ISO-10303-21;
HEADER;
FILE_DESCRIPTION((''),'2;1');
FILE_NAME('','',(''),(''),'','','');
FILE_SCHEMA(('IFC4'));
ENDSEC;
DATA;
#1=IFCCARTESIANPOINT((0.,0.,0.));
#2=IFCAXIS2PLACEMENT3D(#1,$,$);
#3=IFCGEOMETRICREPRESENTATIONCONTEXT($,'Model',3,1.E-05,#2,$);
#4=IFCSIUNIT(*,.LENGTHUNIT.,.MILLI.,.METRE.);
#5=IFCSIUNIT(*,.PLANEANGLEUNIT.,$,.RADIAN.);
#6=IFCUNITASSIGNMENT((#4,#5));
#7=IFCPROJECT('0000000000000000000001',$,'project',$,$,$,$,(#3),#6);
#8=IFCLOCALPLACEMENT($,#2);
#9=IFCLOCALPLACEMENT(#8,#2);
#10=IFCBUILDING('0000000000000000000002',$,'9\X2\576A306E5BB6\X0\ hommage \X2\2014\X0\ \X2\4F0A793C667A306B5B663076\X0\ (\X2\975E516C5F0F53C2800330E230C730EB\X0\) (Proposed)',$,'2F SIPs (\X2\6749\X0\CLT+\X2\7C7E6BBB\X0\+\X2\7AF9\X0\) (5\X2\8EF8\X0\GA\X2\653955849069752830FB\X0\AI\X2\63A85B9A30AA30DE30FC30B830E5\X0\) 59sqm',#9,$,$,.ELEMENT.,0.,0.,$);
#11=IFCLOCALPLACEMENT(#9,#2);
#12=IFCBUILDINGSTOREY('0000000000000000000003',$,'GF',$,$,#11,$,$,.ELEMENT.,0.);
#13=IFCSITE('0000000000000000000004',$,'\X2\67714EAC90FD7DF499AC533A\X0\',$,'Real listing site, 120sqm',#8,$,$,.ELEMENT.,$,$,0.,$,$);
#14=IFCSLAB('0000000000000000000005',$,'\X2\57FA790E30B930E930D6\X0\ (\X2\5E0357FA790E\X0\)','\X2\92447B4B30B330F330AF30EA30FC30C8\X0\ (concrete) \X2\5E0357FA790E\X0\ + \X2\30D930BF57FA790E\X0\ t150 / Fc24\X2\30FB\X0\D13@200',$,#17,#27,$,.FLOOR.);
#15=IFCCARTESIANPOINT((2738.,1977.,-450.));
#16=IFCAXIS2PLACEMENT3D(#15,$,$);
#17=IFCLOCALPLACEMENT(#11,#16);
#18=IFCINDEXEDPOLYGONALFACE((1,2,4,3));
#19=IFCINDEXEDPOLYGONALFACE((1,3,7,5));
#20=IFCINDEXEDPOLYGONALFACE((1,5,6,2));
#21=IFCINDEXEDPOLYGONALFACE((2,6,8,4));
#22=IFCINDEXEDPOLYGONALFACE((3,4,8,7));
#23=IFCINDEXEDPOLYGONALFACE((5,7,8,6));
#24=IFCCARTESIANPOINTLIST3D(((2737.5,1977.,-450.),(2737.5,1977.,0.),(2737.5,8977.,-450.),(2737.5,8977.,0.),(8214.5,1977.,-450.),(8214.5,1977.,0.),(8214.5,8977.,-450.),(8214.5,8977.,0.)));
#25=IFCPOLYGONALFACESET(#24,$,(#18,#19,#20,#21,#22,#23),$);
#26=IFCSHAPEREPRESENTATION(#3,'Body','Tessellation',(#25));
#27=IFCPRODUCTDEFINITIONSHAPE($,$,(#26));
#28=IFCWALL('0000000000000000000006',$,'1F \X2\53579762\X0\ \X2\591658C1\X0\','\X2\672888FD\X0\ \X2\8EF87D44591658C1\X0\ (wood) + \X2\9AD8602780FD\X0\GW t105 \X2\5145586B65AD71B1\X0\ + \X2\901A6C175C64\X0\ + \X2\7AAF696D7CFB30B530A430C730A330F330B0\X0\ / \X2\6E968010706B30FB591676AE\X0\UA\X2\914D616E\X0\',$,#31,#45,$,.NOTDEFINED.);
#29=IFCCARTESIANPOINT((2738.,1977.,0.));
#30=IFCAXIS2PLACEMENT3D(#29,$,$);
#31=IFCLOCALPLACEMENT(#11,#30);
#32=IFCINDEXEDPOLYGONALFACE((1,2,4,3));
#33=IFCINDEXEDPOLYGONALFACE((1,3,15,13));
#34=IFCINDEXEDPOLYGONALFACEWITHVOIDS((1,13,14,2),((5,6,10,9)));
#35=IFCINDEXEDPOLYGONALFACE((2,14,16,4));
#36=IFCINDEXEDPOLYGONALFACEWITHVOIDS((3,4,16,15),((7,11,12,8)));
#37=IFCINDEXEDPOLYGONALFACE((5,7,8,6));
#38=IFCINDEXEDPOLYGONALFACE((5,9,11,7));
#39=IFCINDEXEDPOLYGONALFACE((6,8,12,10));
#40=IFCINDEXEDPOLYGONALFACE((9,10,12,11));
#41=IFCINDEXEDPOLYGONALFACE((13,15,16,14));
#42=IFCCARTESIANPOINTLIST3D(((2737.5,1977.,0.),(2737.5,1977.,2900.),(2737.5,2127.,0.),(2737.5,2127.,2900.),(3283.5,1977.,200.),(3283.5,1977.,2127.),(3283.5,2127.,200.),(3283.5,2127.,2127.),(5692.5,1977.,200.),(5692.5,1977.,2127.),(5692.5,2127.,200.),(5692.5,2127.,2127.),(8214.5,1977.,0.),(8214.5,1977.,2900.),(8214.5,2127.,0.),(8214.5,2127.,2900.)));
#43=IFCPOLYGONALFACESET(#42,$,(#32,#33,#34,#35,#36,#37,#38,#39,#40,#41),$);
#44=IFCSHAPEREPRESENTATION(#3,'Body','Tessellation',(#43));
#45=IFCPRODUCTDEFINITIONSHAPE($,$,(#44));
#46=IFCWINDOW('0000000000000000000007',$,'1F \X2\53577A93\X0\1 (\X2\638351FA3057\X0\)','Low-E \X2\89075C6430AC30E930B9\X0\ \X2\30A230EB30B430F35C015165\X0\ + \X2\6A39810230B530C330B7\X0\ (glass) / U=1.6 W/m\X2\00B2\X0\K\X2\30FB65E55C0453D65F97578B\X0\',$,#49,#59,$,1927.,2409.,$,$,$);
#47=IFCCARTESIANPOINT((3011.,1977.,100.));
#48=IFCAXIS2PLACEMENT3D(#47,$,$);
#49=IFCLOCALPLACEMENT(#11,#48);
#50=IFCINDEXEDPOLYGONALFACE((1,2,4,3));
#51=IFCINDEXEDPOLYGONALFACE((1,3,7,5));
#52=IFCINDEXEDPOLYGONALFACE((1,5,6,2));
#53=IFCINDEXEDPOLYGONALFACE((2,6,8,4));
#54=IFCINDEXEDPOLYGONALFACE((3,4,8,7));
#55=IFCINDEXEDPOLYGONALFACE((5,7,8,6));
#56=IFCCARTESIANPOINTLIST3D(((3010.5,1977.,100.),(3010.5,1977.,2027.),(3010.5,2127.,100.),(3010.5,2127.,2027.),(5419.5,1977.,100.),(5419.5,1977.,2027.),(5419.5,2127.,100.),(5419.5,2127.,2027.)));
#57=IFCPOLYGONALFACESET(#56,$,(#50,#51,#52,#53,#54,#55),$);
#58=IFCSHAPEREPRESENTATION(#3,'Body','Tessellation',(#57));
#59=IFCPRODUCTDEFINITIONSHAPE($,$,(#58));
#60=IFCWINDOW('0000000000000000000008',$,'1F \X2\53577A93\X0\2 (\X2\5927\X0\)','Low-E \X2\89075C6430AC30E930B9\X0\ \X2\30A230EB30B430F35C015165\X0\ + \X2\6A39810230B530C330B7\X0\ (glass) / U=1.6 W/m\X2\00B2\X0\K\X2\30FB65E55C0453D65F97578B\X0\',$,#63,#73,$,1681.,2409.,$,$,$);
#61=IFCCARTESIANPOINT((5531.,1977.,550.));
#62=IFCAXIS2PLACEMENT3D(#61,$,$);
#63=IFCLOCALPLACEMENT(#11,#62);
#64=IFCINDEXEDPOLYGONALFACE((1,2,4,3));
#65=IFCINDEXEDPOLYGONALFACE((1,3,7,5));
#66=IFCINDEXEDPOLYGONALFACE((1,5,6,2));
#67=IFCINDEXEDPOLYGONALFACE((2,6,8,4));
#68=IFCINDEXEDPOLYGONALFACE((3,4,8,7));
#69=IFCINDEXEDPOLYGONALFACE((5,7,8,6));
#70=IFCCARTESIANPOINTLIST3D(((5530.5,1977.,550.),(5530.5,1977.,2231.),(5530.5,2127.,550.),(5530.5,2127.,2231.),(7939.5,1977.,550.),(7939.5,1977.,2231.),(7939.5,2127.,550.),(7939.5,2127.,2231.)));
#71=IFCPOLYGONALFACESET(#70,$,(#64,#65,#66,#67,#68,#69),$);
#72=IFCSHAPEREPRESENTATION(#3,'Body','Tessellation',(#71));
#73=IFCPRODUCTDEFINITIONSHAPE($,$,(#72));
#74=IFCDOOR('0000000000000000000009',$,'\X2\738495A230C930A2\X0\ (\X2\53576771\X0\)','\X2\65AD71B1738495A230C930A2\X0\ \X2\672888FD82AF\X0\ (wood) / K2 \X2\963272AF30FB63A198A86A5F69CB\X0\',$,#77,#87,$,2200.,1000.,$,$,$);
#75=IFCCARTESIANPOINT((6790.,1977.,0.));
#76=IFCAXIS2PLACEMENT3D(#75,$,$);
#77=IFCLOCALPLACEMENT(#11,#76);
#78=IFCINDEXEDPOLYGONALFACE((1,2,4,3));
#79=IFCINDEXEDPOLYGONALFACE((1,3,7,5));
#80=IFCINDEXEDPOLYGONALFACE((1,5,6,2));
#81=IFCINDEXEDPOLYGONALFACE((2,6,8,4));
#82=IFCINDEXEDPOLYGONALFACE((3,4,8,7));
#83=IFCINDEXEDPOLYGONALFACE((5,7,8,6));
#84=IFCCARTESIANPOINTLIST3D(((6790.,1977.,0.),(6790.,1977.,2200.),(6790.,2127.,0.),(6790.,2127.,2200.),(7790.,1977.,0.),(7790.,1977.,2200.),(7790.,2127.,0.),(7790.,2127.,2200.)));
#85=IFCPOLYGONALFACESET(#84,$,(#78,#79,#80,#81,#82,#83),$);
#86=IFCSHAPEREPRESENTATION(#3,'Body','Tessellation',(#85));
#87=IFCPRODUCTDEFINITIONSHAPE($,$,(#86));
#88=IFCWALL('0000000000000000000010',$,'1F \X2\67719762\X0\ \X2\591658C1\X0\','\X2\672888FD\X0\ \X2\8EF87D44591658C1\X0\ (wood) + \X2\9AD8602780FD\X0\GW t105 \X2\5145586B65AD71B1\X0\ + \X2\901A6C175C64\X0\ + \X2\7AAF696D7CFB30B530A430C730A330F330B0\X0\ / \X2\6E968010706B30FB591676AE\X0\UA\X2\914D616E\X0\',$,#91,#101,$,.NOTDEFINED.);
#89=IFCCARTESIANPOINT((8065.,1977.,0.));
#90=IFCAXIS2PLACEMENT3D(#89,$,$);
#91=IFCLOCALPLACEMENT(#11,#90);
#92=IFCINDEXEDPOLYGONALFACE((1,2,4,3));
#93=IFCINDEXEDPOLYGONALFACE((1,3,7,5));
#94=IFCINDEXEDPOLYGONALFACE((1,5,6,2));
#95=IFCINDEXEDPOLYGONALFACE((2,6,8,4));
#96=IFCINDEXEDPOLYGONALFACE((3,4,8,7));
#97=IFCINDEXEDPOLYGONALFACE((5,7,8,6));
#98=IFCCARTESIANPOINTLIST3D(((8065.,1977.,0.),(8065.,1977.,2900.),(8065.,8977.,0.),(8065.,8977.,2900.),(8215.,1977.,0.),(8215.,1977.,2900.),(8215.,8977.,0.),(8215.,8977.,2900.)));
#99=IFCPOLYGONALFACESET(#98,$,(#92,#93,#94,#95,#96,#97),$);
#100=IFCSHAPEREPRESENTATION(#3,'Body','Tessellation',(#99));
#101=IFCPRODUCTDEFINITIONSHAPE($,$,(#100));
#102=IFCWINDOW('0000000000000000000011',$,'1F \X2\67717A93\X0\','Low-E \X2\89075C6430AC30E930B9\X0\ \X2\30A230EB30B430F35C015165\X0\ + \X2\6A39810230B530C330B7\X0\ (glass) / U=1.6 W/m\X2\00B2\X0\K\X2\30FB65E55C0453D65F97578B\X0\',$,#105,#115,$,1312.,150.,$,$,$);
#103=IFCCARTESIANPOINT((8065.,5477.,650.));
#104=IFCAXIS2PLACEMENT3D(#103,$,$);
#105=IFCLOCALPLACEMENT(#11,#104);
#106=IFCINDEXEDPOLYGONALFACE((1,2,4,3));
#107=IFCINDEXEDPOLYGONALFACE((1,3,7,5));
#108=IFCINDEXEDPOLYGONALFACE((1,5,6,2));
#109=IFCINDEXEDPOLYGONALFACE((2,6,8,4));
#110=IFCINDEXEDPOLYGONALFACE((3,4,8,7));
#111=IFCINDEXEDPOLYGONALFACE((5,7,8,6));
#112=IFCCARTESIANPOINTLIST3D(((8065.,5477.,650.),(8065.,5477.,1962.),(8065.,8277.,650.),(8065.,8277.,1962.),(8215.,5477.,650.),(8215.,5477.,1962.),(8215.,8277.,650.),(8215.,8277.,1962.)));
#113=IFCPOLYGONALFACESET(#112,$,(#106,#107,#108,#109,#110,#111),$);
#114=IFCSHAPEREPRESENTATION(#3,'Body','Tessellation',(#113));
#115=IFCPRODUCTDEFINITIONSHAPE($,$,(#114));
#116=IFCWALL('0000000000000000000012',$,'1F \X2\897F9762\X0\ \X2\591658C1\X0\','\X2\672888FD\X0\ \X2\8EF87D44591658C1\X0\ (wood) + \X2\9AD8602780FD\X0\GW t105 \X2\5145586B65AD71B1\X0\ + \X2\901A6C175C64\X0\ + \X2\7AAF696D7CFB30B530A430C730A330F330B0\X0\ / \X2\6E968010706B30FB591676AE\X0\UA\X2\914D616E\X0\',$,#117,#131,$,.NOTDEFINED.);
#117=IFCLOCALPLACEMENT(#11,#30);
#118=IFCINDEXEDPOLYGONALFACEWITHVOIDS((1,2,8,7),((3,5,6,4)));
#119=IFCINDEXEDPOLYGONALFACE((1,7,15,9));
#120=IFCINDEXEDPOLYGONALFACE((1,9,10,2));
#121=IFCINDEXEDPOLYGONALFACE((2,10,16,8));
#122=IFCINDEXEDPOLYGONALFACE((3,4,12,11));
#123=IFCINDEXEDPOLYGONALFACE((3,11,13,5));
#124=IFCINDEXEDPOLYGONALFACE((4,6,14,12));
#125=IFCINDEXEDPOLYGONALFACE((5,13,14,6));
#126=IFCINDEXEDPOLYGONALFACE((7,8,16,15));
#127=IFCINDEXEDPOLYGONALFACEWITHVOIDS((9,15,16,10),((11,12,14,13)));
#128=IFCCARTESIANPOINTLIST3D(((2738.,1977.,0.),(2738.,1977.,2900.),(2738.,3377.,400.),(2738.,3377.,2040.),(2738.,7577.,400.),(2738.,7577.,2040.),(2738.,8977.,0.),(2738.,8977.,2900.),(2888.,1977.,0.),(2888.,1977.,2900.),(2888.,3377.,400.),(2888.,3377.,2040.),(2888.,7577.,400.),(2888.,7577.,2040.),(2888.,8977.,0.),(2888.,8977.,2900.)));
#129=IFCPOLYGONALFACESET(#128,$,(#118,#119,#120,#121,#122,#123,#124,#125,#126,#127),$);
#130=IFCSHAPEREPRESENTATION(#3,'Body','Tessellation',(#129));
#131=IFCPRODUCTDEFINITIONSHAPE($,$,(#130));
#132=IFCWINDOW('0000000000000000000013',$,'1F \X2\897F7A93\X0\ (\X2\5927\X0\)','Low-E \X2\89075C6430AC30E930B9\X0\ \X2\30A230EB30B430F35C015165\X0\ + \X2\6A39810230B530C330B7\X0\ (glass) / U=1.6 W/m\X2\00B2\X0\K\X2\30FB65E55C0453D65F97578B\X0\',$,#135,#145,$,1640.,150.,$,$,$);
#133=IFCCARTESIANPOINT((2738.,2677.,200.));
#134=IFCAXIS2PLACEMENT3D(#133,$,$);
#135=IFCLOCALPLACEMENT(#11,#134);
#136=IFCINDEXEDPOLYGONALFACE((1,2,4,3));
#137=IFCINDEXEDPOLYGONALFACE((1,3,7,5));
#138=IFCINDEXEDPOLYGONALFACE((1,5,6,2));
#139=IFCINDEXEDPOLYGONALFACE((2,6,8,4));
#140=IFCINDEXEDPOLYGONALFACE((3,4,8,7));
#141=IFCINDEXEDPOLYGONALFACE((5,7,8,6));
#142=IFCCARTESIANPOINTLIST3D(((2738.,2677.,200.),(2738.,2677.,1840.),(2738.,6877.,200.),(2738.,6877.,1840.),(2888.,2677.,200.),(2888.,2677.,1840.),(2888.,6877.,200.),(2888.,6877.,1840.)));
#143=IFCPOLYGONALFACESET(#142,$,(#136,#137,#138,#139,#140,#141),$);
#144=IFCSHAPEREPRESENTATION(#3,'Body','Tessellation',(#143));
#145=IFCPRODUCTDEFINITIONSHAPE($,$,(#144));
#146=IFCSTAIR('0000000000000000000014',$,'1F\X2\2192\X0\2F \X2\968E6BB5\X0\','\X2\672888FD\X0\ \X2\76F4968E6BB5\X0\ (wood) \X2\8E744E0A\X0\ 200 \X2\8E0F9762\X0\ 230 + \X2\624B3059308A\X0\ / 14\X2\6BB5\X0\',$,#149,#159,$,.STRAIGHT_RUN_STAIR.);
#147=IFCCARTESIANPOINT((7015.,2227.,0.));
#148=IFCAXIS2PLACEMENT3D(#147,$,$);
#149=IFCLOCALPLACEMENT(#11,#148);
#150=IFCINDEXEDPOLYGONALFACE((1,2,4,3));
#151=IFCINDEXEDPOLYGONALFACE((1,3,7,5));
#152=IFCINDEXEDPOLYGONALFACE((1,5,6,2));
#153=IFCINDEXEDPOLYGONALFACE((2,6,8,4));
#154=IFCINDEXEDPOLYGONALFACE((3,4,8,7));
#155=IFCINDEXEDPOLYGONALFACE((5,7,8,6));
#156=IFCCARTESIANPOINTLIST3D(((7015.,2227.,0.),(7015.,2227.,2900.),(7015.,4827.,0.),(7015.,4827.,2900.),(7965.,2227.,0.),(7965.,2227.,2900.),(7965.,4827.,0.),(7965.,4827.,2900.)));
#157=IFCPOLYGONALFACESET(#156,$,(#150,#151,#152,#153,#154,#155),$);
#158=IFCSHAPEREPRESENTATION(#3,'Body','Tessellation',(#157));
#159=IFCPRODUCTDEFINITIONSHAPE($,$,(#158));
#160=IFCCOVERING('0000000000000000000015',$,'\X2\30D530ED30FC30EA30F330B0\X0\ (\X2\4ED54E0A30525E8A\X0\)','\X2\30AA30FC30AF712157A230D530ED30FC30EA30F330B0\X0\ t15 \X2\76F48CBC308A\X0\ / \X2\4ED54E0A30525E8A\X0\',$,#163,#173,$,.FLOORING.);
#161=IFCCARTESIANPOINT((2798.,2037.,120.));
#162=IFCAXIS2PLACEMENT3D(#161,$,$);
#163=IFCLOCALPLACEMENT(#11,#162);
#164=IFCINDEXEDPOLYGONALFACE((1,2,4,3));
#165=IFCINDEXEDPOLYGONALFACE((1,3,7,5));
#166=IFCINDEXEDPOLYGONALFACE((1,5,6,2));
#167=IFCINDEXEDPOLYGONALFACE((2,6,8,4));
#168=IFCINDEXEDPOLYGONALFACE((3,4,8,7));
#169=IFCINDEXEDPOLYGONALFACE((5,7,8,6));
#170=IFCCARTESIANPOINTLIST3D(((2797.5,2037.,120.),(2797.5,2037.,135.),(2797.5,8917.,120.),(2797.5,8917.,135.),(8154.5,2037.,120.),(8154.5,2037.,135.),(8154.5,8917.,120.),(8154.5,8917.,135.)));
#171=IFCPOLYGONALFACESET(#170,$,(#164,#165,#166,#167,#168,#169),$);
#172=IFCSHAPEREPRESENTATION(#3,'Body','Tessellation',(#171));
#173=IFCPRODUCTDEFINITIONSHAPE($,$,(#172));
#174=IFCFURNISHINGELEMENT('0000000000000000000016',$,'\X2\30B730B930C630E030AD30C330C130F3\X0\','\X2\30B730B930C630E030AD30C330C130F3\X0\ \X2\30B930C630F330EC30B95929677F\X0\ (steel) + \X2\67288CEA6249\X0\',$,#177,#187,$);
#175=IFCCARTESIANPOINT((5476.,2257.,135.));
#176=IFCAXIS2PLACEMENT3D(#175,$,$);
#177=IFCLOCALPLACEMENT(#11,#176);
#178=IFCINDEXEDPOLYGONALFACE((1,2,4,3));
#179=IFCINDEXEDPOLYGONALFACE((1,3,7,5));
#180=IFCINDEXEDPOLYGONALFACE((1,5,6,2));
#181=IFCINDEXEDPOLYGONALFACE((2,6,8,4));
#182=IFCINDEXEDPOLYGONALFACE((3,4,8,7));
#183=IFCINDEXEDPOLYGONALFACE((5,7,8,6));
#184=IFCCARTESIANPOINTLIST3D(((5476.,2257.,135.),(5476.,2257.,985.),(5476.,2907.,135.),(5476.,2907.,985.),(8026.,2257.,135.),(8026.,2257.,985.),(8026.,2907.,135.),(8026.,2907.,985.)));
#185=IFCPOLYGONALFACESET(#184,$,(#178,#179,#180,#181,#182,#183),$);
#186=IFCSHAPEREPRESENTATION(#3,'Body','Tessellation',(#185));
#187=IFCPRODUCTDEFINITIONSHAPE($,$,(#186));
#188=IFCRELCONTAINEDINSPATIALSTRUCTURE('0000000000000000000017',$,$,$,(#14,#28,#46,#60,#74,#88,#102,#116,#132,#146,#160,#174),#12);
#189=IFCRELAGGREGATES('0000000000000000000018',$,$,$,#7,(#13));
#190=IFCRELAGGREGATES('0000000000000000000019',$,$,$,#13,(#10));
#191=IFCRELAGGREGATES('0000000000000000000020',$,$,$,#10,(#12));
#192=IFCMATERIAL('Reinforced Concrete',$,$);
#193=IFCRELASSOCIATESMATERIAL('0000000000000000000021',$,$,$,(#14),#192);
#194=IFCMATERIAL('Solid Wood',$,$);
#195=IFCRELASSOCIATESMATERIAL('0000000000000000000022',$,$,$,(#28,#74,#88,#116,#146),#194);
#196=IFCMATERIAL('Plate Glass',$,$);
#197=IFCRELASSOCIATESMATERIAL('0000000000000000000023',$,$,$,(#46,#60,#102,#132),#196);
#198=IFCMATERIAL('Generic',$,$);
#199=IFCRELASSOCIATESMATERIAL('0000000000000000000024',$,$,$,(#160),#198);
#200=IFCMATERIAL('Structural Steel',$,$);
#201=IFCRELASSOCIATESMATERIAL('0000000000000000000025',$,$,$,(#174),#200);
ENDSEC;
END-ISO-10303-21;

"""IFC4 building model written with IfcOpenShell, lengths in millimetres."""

from ifc_helpers import new_model, si_unit, frame, frame_2d, origin, place, context, project, spatial, rectangle, extrude, material, element, fill, save


model = new_model("IFC4")

# Units and contexts
model_context = context("Model", 3, precision=1e-05, world=origin())
ifc_project = project(units=[si_unit("LENGTHUNIT", "METRE", prefix="MILLI"), si_unit("PLANEANGLEUNIT", "RADIAN")], contexts=[model_context])

# Site, building, storey
site_placement = place(None, origin())
site = spatial("IfcSite", under=ifc_project, at=site_placement, Name="東京都練馬区", ObjectType="Real listing site, 120sqm", CompositionType="ELEMENT", RefElevation=0.0)
building_placement = place(site_placement, origin())
building = spatial("IfcBuilding", under=site, at=building_placement, Name="9坪の家 hommage — 伊礼智に学ぶ (非公式参考モデル) (Proposed)", ObjectType="2F SIPs (杉CLT+籾殻+竹) (5軸GA改善適用・AI推定オマージュ) 59sqm", CompositionType="ELEMENT", ElevationOfRefHeight=0.0, ElevationOfTerrain=0.0)
storey_placement = place(building_placement, origin())
storey = spatial("IfcBuildingStorey", under=building, at=storey_placement, Name="GF", CompositionType="ELEMENT", Elevation=0.0)

# Slab
ifc_material_1 = material(Name="Reinforced Concrete")
slab_1_placement = place(storey_placement, frame((2738.0, 1977.0, -450.0)))
element("IfcSlab", 1, at=slab_1_placement, inside=storey, material=ifc_material_1, Name="基礎スラブ (布基礎)", Description="鉄筋コンクリート (concrete) 布基礎 + ベタ基礎 t150 / Fc24・D13@200", PredefinedType="FLOOR", context=model_context, shape_type="SweptSolid", body=[
    extrude(rectangle(XDim=5477.0, YDim=7000.0, at=frame_2d((2738.0, 3500.0))), frame((2738.0, 1977.0, -450.0)), (0.0, 0.0, 1.0), 450.0),
])
ifc_material_2 = material(Name="Solid Wood")

# Wall, openings, windows, door
wall_1_placement = place(storey_placement, frame((2738.0, 1977.0, 0.0)))
wall_1 = element("IfcWall", 2, at=wall_1_placement, inside=storey, material=ifc_material_2, Name="1F 南面 外壁", Description="木製 軸組外壁 (wood) + 高性能GW t105 充填断熱 + 通気層 + 窯業系サイディング / 準耐火・外皮UA配慮", PredefinedType="NOTDEFINED", context=model_context, shape_type="SweptSolid", body=[
    extrude(rectangle(XDim=5477.0, YDim=150.0, at=frame_2d((2738.0, 75.0))), frame((2738.0, 1977.0, 0.0)), (0.0, 0.0, 1.0), 2900.0),
])
opening_1_placement = place(storey_placement, frame((3011.0, 1977.0, 100.0)))
opening_1 = element("IfcOpeningElement", 3, at=opening_1_placement, cuts=wall_1, PredefinedType="NOTDEFINED", context=model_context, shape_type="SweptSolid", body=[
    extrude(rectangle(XDim=2409.0, YDim=150.0, at=frame_2d((1204.0, 75.0))), frame((3011.0, 1977.0, 100.0)), (0.0, 0.0, 1.0), 1927.0),
])
opening_2_placement = place(storey_placement, frame((5531.0, 1977.0, 550.0)))
opening_2 = element("IfcOpeningElement", 4, at=opening_2_placement, cuts=wall_1, PredefinedType="NOTDEFINED", context=model_context, shape_type="SweptSolid", body=[
    extrude(rectangle(XDim=2409.0, YDim=150.0, at=frame_2d((1204.0, 75.0))), frame((5531.0, 1977.0, 550.0)), (0.0, 0.0, 1.0), 1681.0),
])
opening_3_placement = place(storey_placement, frame((6790.0, 1977.0, 0.0)))
opening_3 = element("IfcOpeningElement", 5, at=opening_3_placement, cuts=wall_1, PredefinedType="NOTDEFINED", context=model_context, shape_type="SweptSolid", body=[
    extrude(rectangle(XDim=1000.0, YDim=150.0, at=frame_2d((500.0, 75.0))), frame((6790.0, 1977.0, 0.0)), (0.0, 0.0, 1.0), 2200.0),
])
ifc_material_3 = material(Name="Plate Glass")
window_1_placement = place(storey_placement, frame((3011.0, 1977.0, 100.0)))
window_1 = element("IfcWindow", 6, at=window_1_placement, inside=storey, material=ifc_material_3, Name="1F 南窓1 (掃出し)", Description="Low-E 複層ガラス アルゴン封入 + 樹脂サッシ (glass) / U=1.6 W/m²K・日射取得型", OverallHeight=1927.0, OverallWidth=2409.0, context=model_context, shape_type="SweptSolid", body=[
    extrude(rectangle(XDim=2409.0, YDim=150.0, at=frame_2d((1204.0, 75.0))), frame((3011.0, 1977.0, 100.0)), (0.0, 0.0, 1.0), 1927.0),
])
fill(opening_1, window_1)
window_2_placement = place(storey_placement, frame((5531.0, 1977.0, 550.0)))
window_2 = element("IfcWindow", 7, at=window_2_placement, inside=storey, material=ifc_material_3, Name="1F 南窓2 (大)", Description="Low-E 複層ガラス アルゴン封入 + 樹脂サッシ (glass) / U=1.6 W/m²K・日射取得型", OverallHeight=1681.0, OverallWidth=2409.0, context=model_context, shape_type="SweptSolid", body=[
    extrude(rectangle(XDim=2409.0, YDim=150.0, at=frame_2d((1204.0, 75.0))), frame((5531.0, 1977.0, 550.0)), (0.0, 0.0, 1.0), 1681.0),
])
fill(opening_2, window_2)
door_placement = place(storey_placement, frame((6790.0, 1977.0, 0.0)))
door = element("IfcDoor", 8, at=door_placement, inside=storey, material=ifc_material_2, Name="玄関ドア (南東)", Description="断熱玄関ドア 木製芯 (wood) / K2 防犯・採風機構", OverallHeight=2200.0, OverallWidth=1000.0, context=model_context, shape_type="SweptSolid", body=[
    extrude(rectangle(XDim=1000.0, YDim=150.0, at=frame_2d((500.0, 75.0))), frame((6790.0, 1977.0, 0.0)), (0.0, 0.0, 1.0), 2200.0),
])
fill(opening_3, door)

# Walls, openings, windows
wall_2_placement = place(storey_placement, frame((8065.0, 1977.0, 0.0)))
wall_2 = element("IfcWall", 9, at=wall_2_placement, inside=storey, material=ifc_material_2, Name="1F 東面 外壁", Description="木製 軸組外壁 (wood) + 高性能GW t105 充填断熱 + 通気層 + 窯業系サイディング / 準耐火・外皮UA配慮", PredefinedType="NOTDEFINED", context=model_context, shape_type="SweptSolid", body=[
    extrude(rectangle(XDim=150.0, YDim=7000.0, at=frame_2d((75.0, 3500.0))), frame((8065.0, 1977.0, 0.0)), (0.0, 0.0, 1.0), 2900.0),
])
opening_4_placement = place(storey_placement, frame((8065.0, 5477.0, 650.0)))
opening_4 = element("IfcOpeningElement", 10, at=opening_4_placement, cuts=wall_2, PredefinedType="NOTDEFINED", context=model_context, shape_type="SweptSolid", body=[
    extrude(rectangle(XDim=150.0, YDim=2800.0, at=frame_2d((75.0, 1400.0))), frame((8065.0, 5477.0, 650.0)), (0.0, 0.0, 1.0), 1312.0),
])
window_3_placement = place(storey_placement, frame((8065.0, 5477.0, 650.0)))
window_3 = element("IfcWindow", 11, at=window_3_placement, inside=storey, material=ifc_material_3, Name="1F 東窓", Description="Low-E 複層ガラス アルゴン封入 + 樹脂サッシ (glass) / U=1.6 W/m²K・日射取得型", OverallHeight=1312.0, OverallWidth=150.0, context=model_context, shape_type="SweptSolid", body=[
    extrude(rectangle(XDim=150.0, YDim=2800.0, at=frame_2d((75.0, 1400.0))), frame((8065.0, 5477.0, 650.0)), (0.0, 0.0, 1.0), 1312.0),
])
fill(opening_4, window_3)
wall_3_placement = place(storey_placement, frame((2738.0, 1977.0, 0.0)))
wall_3 = element("IfcWall", 12, at=wall_3_placement, inside=storey, material=ifc_material_2, Name="1F 西面 外壁", Description="木製 軸組外壁 (wood) + 高性能GW t105 充填断熱 + 通気層 + 窯業系サイディング / 準耐火・外皮UA配慮", PredefinedType="NOTDEFINED", context=model_context, shape_type="SweptSolid", body=[
    extrude(rectangle(XDim=150.0, YDim=7000.0, at=frame_2d((75.0, 3500.0))), frame((2738.0, 1977.0, 0.0)), (0.0, 0.0, 1.0), 2900.0),
])
opening_5_placement = place(storey_placement, frame((2738.0, 2677.0, 200.0)))
opening_5 = element("IfcOpeningElement", 13, at=opening_5_placement, cuts=wall_3, PredefinedType="NOTDEFINED", context=model_context, shape_type="SweptSolid", body=[
    extrude(rectangle(XDim=150.0, YDim=4200.0, at=frame_2d((75.0, 2100.0))), frame((2738.0, 2677.0, 200.0)), (0.0, 0.0, 1.0), 1640.0),
])
window_4_placement = place(storey_placement, frame((2738.0, 2677.0, 200.0)))
window_4 = element("IfcWindow", 14, at=window_4_placement, inside=storey, material=ifc_material_3, Name="1F 西窓 (大)", Description="Low-E 複層ガラス アルゴン封入 + 樹脂サッシ (glass) / U=1.6 W/m²K・日射取得型", OverallHeight=1640.0, OverallWidth=150.0, context=model_context, shape_type="SweptSolid", body=[
    extrude(rectangle(XDim=150.0, YDim=4200.0, at=frame_2d((75.0, 2100.0))), frame((2738.0, 2677.0, 200.0)), (0.0, 0.0, 1.0), 1640.0),
])
fill(opening_5, window_4)

# Stair
stair_placement = place(storey_placement, frame((7015.0, 2227.0, 0.0)))
element("IfcStair", 15, at=stair_placement, inside=storey, material=ifc_material_2, Name="1F→2F 階段", Description="木製 直階段 (wood) 蹴上 200 踏面 230 + 手すり / 14段", PredefinedType="STRAIGHT_RUN_STAIR", context=model_context, shape_type="SweptSolid", body=[
    extrude(rectangle(XDim=950.0, YDim=2600.0, at=frame_2d((475.0, 1300.0))), frame((7015.0, 2227.0, 0.0)), (0.0, 0.0, 1.0), 2900.0),
])

# Covering
ifc_material_4 = material(Name="Generic")
covering_placement = place(storey_placement, frame((2798.0, 2037.0, 120.0)))
element("IfcCovering", 16, at=covering_placement, inside=storey, material=ifc_material_4, Name="フローリング (仕上げ床)", Description="オーク無垢フローリング t15 直貼り / 仕上げ床", PredefinedType="FLOORING", context=model_context, shape_type="SweptSolid", body=[
    extrude(rectangle(XDim=5357.0, YDim=6880.0, at=frame_2d((2678.0, 3440.0))), frame((2798.0, 2037.0, 120.0)), (0.0, 0.0, 1.0), 15.0),
])

# Furnishing element
ifc_material_5 = material(Name="Structural Steel")
furnishing_placement = place(storey_placement, frame((5476.0, 2257.0, 135.0)))
element("IfcFurnishingElement", 17, at=furnishing_placement, inside=storey, material=ifc_material_5, Name="システムキッチン", Description="システムキッチン ステンレス天板 (steel) + 木質扉", context=model_context, shape_type="SweptSolid", body=[
    extrude(rectangle(XDim=2550.0, YDim=650.0, at=frame_2d((1275.0, 325.0))), frame((5476.0, 2257.0, 135.0)), (0.0, 0.0, 1.0), 850.0),
])

save(model, "model.ifc")
